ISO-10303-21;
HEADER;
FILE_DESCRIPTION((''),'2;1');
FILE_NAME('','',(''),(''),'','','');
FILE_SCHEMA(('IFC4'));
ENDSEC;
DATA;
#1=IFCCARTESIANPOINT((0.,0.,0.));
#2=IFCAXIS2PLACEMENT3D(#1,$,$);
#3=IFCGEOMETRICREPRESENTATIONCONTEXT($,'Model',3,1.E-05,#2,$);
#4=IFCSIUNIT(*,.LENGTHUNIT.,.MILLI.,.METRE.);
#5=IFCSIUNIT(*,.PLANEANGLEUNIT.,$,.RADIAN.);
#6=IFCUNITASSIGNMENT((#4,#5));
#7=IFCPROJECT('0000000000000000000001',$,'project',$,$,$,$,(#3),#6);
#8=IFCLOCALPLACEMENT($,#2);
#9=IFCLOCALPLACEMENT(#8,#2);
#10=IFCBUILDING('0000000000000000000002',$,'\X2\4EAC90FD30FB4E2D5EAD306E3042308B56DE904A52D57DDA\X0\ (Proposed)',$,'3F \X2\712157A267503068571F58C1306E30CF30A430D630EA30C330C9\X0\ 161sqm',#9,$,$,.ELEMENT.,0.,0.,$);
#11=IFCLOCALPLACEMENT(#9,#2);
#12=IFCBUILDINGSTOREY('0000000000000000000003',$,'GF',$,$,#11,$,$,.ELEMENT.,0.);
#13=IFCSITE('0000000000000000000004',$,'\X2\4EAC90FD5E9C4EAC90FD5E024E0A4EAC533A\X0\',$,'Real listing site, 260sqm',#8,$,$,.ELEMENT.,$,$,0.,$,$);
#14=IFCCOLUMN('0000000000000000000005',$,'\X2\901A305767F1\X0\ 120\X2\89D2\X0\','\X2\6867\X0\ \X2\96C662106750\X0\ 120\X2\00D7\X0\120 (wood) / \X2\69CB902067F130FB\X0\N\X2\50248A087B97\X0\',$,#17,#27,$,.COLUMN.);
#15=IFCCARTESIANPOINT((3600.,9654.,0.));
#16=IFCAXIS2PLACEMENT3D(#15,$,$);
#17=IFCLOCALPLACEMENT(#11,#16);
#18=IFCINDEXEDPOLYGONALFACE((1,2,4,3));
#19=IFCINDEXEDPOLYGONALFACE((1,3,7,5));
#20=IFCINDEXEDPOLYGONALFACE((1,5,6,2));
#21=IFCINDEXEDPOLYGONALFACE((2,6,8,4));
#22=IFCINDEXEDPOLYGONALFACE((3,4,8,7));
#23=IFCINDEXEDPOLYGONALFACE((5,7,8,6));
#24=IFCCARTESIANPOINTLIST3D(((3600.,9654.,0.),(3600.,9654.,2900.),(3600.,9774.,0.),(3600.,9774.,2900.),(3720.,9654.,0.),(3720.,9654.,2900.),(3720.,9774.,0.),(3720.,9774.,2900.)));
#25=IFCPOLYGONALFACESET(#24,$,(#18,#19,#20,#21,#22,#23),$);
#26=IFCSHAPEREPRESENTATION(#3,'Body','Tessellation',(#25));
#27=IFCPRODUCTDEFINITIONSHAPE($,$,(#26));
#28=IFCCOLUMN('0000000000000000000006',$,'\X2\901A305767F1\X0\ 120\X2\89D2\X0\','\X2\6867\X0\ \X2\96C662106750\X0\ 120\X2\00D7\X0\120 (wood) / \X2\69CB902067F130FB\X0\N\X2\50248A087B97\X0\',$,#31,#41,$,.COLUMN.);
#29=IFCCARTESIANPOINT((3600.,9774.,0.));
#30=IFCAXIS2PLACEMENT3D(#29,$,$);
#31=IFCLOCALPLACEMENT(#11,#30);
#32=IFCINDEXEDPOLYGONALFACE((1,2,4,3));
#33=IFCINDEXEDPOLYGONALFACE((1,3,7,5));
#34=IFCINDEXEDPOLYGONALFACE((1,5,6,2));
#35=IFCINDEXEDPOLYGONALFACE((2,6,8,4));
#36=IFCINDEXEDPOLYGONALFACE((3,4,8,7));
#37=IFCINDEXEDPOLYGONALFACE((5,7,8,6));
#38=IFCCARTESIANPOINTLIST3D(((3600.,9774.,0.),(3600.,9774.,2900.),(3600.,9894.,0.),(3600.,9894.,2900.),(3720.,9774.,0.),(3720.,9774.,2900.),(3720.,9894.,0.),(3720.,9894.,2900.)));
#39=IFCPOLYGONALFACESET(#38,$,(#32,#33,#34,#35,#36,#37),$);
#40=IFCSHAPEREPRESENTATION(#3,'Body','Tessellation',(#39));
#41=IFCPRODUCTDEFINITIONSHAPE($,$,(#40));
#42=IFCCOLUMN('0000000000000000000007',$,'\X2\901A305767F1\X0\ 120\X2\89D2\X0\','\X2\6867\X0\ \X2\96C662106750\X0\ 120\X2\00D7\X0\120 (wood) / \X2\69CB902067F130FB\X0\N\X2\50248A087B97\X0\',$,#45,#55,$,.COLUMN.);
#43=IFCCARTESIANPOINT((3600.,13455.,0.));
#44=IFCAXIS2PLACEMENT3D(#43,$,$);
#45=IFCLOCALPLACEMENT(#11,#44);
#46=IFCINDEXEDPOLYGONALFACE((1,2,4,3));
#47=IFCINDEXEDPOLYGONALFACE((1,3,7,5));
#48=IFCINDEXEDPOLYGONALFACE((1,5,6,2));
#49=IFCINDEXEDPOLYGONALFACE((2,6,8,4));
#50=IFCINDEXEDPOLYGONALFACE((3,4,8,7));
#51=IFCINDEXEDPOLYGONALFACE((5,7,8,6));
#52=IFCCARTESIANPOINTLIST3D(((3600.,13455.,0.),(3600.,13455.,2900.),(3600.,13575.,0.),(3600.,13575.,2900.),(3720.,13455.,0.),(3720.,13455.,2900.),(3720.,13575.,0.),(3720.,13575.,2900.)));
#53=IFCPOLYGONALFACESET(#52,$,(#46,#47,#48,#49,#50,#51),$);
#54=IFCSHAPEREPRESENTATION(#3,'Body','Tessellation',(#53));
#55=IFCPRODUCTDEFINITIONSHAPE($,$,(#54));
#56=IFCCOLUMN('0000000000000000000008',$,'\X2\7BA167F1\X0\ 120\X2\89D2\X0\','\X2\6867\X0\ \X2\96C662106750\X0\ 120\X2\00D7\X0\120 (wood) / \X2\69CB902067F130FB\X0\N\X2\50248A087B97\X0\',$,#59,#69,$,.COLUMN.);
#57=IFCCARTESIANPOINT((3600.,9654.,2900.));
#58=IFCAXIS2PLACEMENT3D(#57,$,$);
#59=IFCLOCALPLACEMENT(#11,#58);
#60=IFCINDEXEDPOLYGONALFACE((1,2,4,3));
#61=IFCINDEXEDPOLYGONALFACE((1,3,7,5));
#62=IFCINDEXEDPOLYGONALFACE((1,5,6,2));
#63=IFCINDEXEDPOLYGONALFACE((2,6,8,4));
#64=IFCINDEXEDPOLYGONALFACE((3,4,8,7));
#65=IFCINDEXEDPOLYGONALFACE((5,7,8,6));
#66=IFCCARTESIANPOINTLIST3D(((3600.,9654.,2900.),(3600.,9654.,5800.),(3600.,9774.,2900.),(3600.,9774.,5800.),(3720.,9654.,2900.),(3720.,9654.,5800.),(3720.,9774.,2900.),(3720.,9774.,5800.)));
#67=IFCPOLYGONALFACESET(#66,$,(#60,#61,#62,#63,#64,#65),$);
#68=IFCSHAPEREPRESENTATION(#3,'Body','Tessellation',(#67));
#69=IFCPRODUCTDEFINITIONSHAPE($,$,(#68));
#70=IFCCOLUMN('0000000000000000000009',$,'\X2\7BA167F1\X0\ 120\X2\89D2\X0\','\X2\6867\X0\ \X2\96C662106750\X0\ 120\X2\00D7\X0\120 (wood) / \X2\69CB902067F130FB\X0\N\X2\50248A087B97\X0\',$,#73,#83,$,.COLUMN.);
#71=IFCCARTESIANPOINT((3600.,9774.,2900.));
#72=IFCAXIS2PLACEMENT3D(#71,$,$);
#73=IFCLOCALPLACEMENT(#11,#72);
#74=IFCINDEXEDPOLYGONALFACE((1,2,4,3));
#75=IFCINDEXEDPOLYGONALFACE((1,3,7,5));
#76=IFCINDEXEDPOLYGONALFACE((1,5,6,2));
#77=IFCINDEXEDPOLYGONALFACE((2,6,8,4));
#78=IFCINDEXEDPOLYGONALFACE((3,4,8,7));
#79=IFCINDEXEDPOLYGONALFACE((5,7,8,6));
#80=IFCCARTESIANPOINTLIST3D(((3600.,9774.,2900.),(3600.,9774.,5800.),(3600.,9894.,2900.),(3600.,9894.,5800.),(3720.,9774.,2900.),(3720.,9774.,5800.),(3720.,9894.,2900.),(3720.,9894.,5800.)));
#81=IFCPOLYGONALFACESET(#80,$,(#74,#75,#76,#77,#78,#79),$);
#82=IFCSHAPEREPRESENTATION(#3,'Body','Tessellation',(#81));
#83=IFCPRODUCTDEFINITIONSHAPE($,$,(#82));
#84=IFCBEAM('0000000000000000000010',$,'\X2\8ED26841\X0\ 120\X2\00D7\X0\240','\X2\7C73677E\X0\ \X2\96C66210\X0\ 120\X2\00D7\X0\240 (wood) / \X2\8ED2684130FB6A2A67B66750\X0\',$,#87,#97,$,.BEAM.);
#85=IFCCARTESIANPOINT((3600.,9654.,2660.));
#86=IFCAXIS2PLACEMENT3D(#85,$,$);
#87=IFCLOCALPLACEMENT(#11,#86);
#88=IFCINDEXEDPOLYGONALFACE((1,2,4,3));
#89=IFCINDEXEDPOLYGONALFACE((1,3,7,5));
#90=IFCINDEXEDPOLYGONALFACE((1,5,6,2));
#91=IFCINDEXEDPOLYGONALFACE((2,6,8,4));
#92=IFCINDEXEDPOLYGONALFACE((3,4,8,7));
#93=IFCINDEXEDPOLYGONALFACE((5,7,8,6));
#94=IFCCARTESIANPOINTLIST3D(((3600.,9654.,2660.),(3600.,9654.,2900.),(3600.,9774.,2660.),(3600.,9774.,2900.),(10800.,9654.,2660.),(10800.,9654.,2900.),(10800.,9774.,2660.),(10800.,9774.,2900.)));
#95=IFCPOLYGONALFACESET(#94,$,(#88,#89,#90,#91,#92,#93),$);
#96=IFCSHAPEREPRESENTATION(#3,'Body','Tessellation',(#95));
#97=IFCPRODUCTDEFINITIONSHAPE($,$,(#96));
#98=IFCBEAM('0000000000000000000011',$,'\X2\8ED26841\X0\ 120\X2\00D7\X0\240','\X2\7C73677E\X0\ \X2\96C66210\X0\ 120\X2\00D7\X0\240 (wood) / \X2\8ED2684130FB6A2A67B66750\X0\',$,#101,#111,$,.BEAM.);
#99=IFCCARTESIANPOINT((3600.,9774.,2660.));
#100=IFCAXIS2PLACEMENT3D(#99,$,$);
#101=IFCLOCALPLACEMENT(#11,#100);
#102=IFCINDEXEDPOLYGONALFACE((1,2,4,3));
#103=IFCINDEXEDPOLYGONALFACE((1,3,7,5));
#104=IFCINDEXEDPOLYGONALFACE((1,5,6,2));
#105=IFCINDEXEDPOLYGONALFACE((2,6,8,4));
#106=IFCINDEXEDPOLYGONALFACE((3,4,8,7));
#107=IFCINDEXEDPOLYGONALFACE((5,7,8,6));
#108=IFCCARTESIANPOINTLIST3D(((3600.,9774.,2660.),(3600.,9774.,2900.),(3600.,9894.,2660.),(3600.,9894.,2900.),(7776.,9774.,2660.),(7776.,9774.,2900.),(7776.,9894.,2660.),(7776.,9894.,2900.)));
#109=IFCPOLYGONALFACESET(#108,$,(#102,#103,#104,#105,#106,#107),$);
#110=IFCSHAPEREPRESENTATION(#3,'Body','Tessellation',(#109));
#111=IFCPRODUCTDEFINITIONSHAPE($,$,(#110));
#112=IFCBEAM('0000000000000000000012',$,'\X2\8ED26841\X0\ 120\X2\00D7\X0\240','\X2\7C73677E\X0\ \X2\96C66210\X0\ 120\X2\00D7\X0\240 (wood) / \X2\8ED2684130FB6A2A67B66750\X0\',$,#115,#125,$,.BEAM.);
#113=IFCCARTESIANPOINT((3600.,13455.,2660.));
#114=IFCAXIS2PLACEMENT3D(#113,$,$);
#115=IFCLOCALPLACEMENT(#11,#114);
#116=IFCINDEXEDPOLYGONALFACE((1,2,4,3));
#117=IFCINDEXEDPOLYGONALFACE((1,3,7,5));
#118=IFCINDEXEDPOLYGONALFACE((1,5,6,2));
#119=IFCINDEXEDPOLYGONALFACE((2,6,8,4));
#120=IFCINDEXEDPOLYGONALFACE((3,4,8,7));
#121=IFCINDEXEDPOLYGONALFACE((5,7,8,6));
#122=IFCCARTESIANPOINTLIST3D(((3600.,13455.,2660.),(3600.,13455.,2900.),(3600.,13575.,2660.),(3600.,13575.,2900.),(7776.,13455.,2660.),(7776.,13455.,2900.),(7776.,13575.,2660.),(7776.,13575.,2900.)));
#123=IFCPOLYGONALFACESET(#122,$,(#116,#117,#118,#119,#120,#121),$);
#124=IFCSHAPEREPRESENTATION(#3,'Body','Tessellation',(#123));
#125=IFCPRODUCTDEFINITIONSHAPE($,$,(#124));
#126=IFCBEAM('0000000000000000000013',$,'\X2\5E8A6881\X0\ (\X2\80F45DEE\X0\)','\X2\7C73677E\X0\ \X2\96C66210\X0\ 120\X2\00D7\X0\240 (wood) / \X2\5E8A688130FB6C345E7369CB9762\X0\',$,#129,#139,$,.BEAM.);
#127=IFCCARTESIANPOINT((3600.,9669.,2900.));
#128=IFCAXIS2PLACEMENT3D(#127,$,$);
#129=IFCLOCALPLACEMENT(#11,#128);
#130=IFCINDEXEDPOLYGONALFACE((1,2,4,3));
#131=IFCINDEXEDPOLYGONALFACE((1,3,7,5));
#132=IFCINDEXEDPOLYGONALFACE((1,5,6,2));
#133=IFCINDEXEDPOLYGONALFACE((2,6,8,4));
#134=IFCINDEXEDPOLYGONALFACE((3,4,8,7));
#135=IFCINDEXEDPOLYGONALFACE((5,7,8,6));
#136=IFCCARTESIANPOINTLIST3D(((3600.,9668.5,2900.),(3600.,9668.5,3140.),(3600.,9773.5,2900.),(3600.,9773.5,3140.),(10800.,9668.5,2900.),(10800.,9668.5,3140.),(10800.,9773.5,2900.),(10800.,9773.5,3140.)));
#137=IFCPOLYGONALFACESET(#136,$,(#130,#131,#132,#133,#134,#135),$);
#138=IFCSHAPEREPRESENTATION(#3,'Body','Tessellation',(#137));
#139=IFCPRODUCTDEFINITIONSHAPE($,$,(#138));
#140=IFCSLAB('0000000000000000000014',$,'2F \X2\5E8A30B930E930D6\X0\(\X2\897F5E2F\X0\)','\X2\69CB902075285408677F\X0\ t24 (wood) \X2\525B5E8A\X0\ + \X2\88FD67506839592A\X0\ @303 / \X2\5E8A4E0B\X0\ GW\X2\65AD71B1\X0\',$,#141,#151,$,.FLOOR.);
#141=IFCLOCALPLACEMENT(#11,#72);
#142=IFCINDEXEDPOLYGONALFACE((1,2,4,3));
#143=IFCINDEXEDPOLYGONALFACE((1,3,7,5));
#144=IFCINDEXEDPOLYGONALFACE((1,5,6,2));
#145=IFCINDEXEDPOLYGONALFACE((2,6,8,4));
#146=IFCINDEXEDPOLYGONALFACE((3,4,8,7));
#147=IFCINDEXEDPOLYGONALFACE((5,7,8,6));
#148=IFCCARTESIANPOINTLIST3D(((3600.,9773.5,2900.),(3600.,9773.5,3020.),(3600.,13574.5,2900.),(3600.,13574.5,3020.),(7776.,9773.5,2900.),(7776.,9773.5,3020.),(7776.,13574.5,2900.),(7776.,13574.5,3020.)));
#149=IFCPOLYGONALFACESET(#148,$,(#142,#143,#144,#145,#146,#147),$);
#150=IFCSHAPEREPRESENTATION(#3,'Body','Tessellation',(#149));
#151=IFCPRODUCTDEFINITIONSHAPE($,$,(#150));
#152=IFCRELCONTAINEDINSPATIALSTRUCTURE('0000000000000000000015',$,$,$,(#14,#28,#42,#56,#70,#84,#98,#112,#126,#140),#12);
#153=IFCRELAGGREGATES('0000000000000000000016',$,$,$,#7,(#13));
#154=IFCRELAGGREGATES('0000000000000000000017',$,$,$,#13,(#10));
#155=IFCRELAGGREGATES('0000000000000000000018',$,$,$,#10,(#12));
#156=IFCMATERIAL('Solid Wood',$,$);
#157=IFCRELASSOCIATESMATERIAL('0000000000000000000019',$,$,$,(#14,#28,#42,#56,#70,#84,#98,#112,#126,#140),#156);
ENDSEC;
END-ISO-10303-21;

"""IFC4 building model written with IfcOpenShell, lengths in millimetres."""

from ifc_helpers import new_model, si_unit, frame, frame_2d, origin, place, context, project, spatial, rectangle, extrude, material, element, save


model = new_model("IFC4")

# Units and contexts
model_context = context("Model", 3, precision=1e-05, world=origin())
ifc_project = project(units=[si_unit("LENGTHUNIT", "METRE", prefix="MILLI"), si_unit("PLANEANGLEUNIT", "RADIAN")], contexts=[model_context])

# Site, building, storey
site_placement = place(None, origin())
site = spatial("IfcSite", under=ifc_project, at=site_placement, Name="京都府京都市上京区", ObjectType="Real listing site, 260sqm", CompositionType="ELEMENT", RefElevation=0.0)
building_placement = place(site_placement, origin())
building = spatial("IfcBuilding", under=site, at=building_placement, Name="京都・中庭のある回遊動線 (Proposed)", ObjectType="3F 無垢材と土壁のハイブリッド 161sqm", CompositionType="ELEMENT", ElevationOfRefHeight=0.0, ElevationOfTerrain=0.0)
storey_placement = place(building_placement, origin())
storey = spatial("IfcBuildingStorey", under=building, at=storey_placement, Name="GF", CompositionType="ELEMENT", Elevation=0.0)

# Columns
ifc_material_1 = material(Name="Solid Wood")
column_1_placement = place(storey_placement, frame((3600.0, 9654.0, 0.0)))
element("IfcColumn", 1, at=column_1_placement, inside=storey, material=ifc_material_1, Name="通し柱 120角", Description="桧 集成材 120×120 (wood) / 構造柱・N値計算", PredefinedType="COLUMN", context=model_context, shape_type="SweptSolid", body=[
    extrude(rectangle(XDim=120.0, YDim=120.0, at=frame_2d((60.0, 60.0))), frame((3600.0, 9654.0, 0.0)), (0.0, 0.0, 1.0), 2900.0),
])
column_2_placement = place(storey_placement, frame((3600.0, 9774.0, 0.0)))
element("IfcColumn", 2, at=column_2_placement, inside=storey, material=ifc_material_1, Name="通し柱 120角", Description="桧 集成材 120×120 (wood) / 構造柱・N値計算", PredefinedType="COLUMN", context=model_context, shape_type="SweptSolid", body=[
    extrude(rectangle(XDim=120.0, YDim=120.0, at=frame_2d((60.0, 60.0))), frame((3600.0, 9774.0, 0.0)), (0.0, 0.0, 1.0), 2900.0),
])
column_3_placement = place(storey_placement, frame((3600.0, 13455.0, 0.0)))
element("IfcColumn", 3, at=column_3_placement, inside=storey, material=ifc_material_1, Name="通し柱 120角", Description="桧 集成材 120×120 (wood) / 構造柱・N値計算", PredefinedType="COLUMN", context=model_context, shape_type="SweptSolid", body=[
    extrude(rectangle(XDim=120.0, YDim=120.0, at=frame_2d((60.0, 60.0))), frame((3600.0, 13455.0, 0.0)), (0.0, 0.0, 1.0), 2900.0),
])
column_4_placement = place(storey_placement, frame((3600.0, 9654.0, 2900.0)))
element("IfcColumn", 4, at=column_4_placement, inside=storey, material=ifc_material_1, Name="管柱 120角", Description="桧 集成材 120×120 (wood) / 構造柱・N値計算", PredefinedType="COLUMN", context=model_context, shape_type="SweptSolid", body=[
    extrude(rectangle(XDim=120.0, YDim=120.0, at=frame_2d((60.0, 60.0))), frame((3600.0, 9654.0, 2900.0)), (0.0, 0.0, 1.0), 2900.0),
])
column_5_placement = place(storey_placement, frame((3600.0, 9774.0, 2900.0)))
element("IfcColumn", 5, at=column_5_placement, inside=storey, material=ifc_material_1, Name="管柱 120角", Description="桧 集成材 120×120 (wood) / 構造柱・N値計算", PredefinedType="COLUMN", context=model_context, shape_type="SweptSolid", body=[
    extrude(rectangle(XDim=120.0, YDim=120.0, at=frame_2d((60.0, 60.0))), frame((3600.0, 9774.0, 2900.0)), (0.0, 0.0, 1.0), 2900.0),
])

# Beams
beam_1_placement = place(storey_placement, frame((3600.0, 9654.0, 2660.0)))
element("IfcBeam", 6, at=beam_1_placement, inside=storey, material=ifc_material_1, Name="軒桁 120×240", Description="米松 集成 120×240 (wood) / 軒桁・横架材", PredefinedType="BEAM", context=model_context, shape_type="SweptSolid", body=[
    extrude(rectangle(XDim=7200.0, YDim=120.0, at=frame_2d((3600.0, 60.0))), frame((3600.0, 9654.0, 2660.0)), (0.0, 0.0, 1.0), 240.0),
])
beam_2_placement = place(storey_placement, frame((3600.0, 9774.0, 2660.0)))
element("IfcBeam", 7, at=beam_2_placement, inside=storey, material=ifc_material_1, Name="軒桁 120×240", Description="米松 集成 120×240 (wood) / 軒桁・横架材", PredefinedType="BEAM", context=model_context, shape_type="SweptSolid", body=[
    extrude(rectangle(XDim=4176.0, YDim=120.0, at=frame_2d((2088.0, 60.0))), frame((3600.0, 9774.0, 2660.0)), (0.0, 0.0, 1.0), 240.0),
])
beam_3_placement = place(storey_placement, frame((3600.0, 13455.0, 2660.0)))
element("IfcBeam", 8, at=beam_3_placement, inside=storey, material=ifc_material_1, Name="軒桁 120×240", Description="米松 集成 120×240 (wood) / 軒桁・横架材", PredefinedType="BEAM", context=model_context, shape_type="SweptSolid", body=[
    extrude(rectangle(XDim=4176.0, YDim=120.0, at=frame_2d((2088.0, 60.0))), frame((3600.0, 13455.0, 2660.0)), (0.0, 0.0, 1.0), 240.0),
])
beam_4_placement = place(storey_placement, frame((3600.0, 9669.0, 2900.0)))
element("IfcBeam", 9, at=beam_4_placement, inside=storey, material=ifc_material_1, Name="床梁 (胴差)", Description="米松 集成 120×240 (wood) / 床梁・水平構面", PredefinedType="BEAM", context=model_context, shape_type="SweptSolid", body=[
    extrude(rectangle(XDim=7200.0, YDim=105.0, at=frame_2d((3600.0, 52.0))), frame((3600.0, 9669.0, 2900.0)), (0.0, 0.0, 1.0), 240.0),
])

# Slab
slab_1_placement = place(storey_placement, frame((3600.0, 9774.0, 2900.0)))
element("IfcSlab", 10, at=slab_1_placement, inside=storey, material=ifc_material_1, Name="2F 床スラブ(西帯)", Description="構造用合板 t24 (wood) 剛床 + 製材根太 @303 / 床下 GW断熱", PredefinedType="FLOOR", context=model_context, shape_type="SweptSolid", body=[
    extrude(rectangle(XDim=4176.0, YDim=3801.0, at=frame_2d((2088.0, 1900.0))), frame((3600.0, 9774.0, 2900.0)), (0.0, 0.0, 1.0), 120.0),
])

save(model, "model.ifc")
